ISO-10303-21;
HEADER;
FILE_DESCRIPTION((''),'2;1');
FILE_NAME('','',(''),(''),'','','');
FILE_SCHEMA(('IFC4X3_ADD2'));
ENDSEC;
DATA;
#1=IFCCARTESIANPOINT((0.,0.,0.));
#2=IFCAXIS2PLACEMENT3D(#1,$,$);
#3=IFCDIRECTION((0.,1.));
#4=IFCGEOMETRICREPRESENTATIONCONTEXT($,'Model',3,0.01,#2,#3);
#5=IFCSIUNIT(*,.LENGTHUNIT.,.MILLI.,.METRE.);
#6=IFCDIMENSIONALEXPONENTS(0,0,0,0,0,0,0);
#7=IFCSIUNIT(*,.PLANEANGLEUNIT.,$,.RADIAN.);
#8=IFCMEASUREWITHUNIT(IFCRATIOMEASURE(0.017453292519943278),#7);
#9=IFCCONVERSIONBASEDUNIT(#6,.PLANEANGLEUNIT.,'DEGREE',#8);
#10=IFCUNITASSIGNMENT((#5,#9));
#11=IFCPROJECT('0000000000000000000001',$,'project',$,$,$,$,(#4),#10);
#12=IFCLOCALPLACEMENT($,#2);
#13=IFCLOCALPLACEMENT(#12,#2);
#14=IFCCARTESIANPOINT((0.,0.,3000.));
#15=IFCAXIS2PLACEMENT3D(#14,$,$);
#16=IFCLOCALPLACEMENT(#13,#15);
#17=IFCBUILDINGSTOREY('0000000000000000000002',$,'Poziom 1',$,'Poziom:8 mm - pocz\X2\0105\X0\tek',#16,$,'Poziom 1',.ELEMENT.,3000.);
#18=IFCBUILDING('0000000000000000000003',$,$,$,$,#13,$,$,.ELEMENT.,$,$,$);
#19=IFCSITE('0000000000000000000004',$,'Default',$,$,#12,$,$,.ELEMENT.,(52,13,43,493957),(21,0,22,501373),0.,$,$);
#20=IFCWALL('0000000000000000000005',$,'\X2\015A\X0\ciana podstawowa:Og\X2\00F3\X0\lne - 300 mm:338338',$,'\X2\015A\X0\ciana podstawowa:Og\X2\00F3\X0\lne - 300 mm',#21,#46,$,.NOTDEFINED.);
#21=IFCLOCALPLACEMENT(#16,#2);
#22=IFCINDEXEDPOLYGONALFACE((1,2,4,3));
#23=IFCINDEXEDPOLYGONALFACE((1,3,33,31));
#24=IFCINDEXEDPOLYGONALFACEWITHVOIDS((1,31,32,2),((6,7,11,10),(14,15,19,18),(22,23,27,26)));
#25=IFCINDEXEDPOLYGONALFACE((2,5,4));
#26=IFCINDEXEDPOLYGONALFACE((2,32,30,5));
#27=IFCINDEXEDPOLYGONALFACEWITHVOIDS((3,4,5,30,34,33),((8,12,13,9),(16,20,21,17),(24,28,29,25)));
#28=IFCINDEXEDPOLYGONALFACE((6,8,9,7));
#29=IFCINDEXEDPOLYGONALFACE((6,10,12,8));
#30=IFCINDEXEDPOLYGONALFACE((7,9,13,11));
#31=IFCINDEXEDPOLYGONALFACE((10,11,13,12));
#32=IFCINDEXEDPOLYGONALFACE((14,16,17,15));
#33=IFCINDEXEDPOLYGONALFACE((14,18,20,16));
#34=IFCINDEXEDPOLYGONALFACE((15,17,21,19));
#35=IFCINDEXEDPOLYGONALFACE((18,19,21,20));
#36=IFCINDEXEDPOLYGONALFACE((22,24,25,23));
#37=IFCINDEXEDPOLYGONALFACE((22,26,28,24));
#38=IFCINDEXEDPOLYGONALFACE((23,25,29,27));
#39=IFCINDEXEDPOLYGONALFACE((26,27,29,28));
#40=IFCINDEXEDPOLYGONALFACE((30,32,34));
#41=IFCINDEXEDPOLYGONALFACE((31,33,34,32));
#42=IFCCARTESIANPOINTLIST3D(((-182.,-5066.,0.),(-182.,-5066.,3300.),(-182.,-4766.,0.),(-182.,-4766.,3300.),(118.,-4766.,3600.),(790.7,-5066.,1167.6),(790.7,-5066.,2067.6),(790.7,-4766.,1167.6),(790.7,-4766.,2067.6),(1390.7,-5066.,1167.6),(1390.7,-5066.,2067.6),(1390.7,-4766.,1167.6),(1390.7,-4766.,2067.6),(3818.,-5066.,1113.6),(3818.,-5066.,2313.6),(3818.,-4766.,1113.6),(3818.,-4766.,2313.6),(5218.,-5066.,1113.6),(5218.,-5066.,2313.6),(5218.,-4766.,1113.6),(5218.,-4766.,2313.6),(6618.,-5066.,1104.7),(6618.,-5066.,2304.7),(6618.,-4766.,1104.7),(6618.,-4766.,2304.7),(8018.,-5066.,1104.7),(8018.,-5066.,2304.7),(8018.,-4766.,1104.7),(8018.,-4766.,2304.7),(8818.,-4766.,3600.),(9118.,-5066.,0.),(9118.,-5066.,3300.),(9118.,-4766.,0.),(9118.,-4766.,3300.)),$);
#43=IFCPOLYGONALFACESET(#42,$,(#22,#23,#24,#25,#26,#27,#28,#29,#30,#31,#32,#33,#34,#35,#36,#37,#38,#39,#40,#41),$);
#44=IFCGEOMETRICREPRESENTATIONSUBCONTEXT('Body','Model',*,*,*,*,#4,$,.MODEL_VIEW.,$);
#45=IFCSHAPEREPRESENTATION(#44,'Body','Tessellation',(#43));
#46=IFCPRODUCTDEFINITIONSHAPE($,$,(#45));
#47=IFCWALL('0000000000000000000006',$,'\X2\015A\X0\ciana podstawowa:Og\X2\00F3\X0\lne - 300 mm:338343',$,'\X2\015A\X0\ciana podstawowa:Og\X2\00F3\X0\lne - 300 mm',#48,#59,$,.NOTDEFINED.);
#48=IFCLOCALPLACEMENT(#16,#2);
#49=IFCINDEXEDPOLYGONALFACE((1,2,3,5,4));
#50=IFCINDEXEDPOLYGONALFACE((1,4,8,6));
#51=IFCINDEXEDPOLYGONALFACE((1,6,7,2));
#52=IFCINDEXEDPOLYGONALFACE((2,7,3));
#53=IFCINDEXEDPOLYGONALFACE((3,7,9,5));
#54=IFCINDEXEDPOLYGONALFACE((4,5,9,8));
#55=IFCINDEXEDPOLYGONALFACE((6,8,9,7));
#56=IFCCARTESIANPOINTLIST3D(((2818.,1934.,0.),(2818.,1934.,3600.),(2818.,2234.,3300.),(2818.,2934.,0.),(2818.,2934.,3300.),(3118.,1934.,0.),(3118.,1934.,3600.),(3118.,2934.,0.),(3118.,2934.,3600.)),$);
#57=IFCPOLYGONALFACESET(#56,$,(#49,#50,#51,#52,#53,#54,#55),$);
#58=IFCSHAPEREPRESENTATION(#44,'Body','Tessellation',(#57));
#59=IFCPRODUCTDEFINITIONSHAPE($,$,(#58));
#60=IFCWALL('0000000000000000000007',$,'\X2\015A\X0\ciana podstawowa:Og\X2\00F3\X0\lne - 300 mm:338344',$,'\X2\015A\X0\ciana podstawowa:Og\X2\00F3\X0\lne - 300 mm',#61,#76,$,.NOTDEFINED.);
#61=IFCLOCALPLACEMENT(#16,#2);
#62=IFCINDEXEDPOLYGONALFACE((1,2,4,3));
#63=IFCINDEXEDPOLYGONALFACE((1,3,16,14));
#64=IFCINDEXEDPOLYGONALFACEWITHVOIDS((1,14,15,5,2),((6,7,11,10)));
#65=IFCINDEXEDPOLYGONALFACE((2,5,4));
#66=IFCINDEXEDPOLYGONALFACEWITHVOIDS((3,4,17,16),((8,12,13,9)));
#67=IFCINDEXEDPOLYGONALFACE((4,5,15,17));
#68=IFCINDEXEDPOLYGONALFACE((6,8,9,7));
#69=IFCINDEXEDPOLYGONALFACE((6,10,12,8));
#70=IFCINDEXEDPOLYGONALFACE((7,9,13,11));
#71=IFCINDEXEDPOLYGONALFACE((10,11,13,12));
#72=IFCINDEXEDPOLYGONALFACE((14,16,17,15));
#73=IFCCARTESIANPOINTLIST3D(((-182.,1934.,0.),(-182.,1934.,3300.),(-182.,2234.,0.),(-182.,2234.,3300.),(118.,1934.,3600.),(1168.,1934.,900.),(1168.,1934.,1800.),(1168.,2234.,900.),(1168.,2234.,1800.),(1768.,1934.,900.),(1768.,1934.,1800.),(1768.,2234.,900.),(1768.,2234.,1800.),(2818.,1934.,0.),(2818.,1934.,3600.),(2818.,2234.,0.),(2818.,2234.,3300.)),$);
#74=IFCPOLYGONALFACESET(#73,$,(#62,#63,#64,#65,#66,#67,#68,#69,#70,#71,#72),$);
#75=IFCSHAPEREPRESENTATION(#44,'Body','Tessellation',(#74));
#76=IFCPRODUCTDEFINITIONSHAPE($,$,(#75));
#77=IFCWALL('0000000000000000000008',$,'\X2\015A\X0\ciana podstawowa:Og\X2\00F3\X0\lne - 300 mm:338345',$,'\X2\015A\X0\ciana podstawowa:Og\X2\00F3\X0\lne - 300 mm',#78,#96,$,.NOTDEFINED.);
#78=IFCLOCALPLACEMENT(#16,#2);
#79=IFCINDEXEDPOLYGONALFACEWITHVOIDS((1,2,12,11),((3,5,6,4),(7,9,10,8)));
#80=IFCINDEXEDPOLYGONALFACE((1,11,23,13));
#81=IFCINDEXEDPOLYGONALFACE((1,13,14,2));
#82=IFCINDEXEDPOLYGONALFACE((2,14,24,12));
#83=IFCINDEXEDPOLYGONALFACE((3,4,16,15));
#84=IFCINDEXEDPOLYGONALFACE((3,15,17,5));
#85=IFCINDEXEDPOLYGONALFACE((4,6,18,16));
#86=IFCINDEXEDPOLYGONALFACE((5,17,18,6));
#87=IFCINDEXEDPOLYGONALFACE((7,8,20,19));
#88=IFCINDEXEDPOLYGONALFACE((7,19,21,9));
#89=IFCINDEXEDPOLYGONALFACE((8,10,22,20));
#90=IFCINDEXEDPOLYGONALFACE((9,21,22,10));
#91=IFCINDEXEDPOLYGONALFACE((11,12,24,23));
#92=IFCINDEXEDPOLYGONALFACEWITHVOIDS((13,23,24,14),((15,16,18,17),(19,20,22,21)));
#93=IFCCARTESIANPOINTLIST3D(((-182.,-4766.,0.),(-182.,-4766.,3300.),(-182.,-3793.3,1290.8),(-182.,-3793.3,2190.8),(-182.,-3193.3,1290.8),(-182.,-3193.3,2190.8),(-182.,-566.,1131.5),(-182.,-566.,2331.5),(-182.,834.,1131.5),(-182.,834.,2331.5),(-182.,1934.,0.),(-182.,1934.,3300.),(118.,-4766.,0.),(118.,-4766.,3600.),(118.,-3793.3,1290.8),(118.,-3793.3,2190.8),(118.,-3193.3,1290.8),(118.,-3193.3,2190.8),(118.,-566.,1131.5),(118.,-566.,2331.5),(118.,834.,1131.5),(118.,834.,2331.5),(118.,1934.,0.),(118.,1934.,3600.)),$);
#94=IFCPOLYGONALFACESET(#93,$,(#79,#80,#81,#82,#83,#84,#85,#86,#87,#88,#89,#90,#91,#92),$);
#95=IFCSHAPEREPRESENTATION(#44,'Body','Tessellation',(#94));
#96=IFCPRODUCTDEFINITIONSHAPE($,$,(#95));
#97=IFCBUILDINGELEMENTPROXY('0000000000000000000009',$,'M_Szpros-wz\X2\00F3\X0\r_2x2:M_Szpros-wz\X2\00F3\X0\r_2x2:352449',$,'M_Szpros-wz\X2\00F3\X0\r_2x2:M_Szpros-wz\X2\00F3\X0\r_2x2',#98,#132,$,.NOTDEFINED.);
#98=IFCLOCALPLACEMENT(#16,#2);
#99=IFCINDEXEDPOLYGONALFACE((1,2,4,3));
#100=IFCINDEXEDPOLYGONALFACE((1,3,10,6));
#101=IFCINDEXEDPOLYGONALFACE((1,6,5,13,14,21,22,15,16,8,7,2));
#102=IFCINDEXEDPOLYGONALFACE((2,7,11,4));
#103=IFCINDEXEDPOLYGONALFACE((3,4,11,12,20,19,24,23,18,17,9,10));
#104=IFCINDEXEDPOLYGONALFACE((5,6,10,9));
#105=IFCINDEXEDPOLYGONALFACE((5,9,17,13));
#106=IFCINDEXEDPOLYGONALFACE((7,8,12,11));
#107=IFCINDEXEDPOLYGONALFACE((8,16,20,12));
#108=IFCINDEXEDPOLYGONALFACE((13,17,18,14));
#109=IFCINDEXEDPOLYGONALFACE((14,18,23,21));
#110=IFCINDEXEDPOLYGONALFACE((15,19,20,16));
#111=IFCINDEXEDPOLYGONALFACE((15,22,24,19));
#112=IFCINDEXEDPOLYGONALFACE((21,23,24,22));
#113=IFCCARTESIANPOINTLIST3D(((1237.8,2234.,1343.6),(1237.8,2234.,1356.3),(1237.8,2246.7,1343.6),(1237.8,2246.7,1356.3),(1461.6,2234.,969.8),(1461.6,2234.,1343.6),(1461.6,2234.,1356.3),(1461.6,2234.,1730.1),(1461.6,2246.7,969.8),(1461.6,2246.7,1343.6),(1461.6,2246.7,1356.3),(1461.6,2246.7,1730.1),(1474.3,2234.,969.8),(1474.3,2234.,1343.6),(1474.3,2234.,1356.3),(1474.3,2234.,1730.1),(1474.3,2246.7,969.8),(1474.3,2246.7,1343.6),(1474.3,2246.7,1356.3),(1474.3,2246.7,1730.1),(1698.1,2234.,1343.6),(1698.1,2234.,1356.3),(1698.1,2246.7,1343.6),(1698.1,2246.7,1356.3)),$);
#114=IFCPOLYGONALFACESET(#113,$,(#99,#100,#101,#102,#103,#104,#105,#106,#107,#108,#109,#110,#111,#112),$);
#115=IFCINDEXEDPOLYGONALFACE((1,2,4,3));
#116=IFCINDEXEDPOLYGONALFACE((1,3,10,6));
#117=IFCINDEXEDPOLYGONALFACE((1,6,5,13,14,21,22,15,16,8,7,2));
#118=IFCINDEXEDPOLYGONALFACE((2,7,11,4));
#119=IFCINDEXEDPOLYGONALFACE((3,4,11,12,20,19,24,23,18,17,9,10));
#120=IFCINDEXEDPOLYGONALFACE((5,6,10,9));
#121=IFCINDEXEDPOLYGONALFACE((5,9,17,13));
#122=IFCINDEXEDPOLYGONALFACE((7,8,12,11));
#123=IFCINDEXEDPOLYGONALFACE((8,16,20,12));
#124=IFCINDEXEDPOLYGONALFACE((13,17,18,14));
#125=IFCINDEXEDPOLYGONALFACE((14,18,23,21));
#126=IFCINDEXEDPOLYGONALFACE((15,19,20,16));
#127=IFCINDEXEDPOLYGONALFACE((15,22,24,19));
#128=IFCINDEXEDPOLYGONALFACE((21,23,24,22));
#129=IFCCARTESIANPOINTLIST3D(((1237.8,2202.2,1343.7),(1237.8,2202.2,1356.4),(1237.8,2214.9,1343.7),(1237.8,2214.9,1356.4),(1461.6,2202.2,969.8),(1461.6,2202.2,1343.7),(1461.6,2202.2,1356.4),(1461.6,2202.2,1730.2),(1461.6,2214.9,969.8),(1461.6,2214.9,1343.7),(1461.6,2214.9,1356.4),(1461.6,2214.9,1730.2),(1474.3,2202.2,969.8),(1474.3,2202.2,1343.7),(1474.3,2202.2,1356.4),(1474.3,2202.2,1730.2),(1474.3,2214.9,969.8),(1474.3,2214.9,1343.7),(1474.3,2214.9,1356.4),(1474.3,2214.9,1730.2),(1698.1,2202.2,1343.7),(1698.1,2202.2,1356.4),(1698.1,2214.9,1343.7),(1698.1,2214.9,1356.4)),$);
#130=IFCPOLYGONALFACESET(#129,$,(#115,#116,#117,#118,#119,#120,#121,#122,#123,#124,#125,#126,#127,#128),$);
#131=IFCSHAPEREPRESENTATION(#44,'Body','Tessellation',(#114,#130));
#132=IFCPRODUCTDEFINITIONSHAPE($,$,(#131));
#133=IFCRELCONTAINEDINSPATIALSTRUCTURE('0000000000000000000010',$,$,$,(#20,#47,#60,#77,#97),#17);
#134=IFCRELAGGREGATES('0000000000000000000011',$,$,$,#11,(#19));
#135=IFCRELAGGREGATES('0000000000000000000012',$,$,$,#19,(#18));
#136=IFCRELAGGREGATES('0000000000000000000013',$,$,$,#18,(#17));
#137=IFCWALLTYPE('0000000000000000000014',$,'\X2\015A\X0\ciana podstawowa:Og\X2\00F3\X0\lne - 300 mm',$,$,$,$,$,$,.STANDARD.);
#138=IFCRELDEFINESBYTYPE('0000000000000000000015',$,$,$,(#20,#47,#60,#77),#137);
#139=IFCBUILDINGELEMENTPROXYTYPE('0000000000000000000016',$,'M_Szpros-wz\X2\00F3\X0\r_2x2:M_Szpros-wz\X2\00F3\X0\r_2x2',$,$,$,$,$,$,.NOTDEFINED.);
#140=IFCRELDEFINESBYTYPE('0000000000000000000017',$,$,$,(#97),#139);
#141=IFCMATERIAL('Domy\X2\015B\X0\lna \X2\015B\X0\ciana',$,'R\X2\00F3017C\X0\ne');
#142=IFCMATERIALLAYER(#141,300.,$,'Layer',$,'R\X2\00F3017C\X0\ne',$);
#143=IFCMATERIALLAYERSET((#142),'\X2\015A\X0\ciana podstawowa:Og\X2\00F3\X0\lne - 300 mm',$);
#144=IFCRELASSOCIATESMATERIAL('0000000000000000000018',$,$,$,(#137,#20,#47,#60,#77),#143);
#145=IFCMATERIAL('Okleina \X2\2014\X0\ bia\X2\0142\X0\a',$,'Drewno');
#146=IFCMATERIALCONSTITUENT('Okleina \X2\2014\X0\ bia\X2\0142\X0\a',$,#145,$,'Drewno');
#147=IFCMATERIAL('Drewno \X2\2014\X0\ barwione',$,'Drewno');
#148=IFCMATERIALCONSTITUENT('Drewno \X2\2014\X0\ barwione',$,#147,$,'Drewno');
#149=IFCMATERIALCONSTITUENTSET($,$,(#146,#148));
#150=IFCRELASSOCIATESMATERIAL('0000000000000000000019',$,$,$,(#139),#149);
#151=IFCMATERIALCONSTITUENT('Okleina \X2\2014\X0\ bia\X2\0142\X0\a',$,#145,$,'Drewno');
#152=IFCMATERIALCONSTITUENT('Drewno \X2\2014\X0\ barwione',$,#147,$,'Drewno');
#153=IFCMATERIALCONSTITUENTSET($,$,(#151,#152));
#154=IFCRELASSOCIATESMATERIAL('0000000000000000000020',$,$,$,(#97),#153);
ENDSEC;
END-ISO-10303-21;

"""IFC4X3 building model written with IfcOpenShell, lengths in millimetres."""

from ifc_helpers import new_model, entity, si_unit, converted_unit, direction, frame, frame_2d, origin, place, context, subcontext, project, spatial, polyline, rectangle, outline, extrude, clip, bounded_halfspace, source, transform, mapped, material, layer, layer_set, constituent, constituent_set, type_object, type_shapes, element, save


model = new_model("IFC4X3")

# Units and contexts
model_context = context("Model", 3, precision=0.01, world=origin(), true_north=direction((0.0, 1.0)))
body_context = subcontext(model_context, "Body", "Model", "MODEL_VIEW")
ifc_project = project(units=[si_unit("LENGTHUNIT", "METRE", prefix="MILLI"), converted_unit("PLANEANGLEUNIT", "DEGREE", entity("IfcRatioMeasure", 0.017453292519943278), si_unit("PLANEANGLEUNIT", "RADIAN"), dimensions=[0, 0, 0, 0, 0, 0, 0])], contexts=[model_context])

# Site, building, storey
site_placement = place(None, origin())
site = spatial("IfcSite", under=ifc_project, at=site_placement, Name="Default", CompositionType="ELEMENT", RefLatitude=(52, 13, 43, 493957), RefLongitude=(21, 0, 22, 501373), RefElevation=0.0)
building_placement = place(site_placement, origin())
building = spatial("IfcBuilding", under=site, at=building_placement, CompositionType="ELEMENT")
storey_placement = place(building_placement, frame((0.0, 0.0, 3000.0)))
storey = spatial("IfcBuildingStorey", under=building, at=storey_placement, Name="Poziom 1", ObjectType="Poziom:8 mm - początek", LongName="Poziom 1", CompositionType="ELEMENT", Elevation=3000.0)

# Wall, openings
ifc_material_1 = material(Name="Domyślna ściana", Category="Różne")
ifc_layer_1 = layer(ifc_material_1, 300.0, Name="Layer", Category="Różne")
ifc_layer_set_1 = layer_set([ifc_layer_1], Name="Ściana podstawowa:Ogólne - 300 mm")
wall_type = type_object("IfcWallType", Name="Ściana podstawowa:Ogólne - 300 mm", PredefinedType="STANDARD", material=ifc_layer_set_1)
wall_1_placement = place(storey_placement, frame((-182.0, -4916.0, 0.0)))
wall_1 = element("IfcWall", 1, at=wall_1_placement, inside=storey, type_object=wall_type, material=ifc_layer_set_1, Name="Ściana podstawowa:Ogólne - 300 mm:338338", ObjectType="Ściana podstawowa:Ogólne - 300 mm", PredefinedType="NOTDEFINED", context=body_context, shape_type="Clipping", body=[
    clip(clip(clip(extrude(rectangle(XDim=9300.0, YDim=300.0, at=frame_2d((4650.0, 0.0), x_axis=(-1.0, 0.0))), origin(), (0.0, 0.0, 1.0), 3600.0), bounded_halfspace(frame((9300.0, -150.0, 3300.0), z_axis=(0.707107, 0.0, 0.707107), x_axis=(0.0, 1.0, 0.0)), False, frame((9300.0, -150.0, 3300.0)), polyline([(0.0, 0.0), (0.0, 300.0), (-300.0, 300.0), (0.0, 0.0)]))), bounded_halfspace(frame((300.0, 150.0, 3600.0), z_axis=(-0.707107, 0.0, 0.707107), x_axis=(0.0, -1.0, 0.0)), False, frame((300.0, 150.0, 3600.0)), polyline([(0.0, 0.0), (-300.0, 0.0), (-300.0, -300.0), (0.0, 0.0)]))), bounded_halfspace(frame((0.0, -150.0, 3300.0), z_axis=(0.0, -0.707107, 0.707107), x_axis=(1.0, 0.0, 0.0)), False, frame((0.0, -150.0, 3300.0)), polyline([(0.0, 0.0), (9300.0, 0.0), (9000.0, 300.0), (300.0, 300.0), (0.0, 0.0)]))),
])
opening_1_placement = place(wall_1_placement, frame((8200.0, 150.0, 1104.7)))
element("IfcOpeningElement", 2, at=opening_1_placement, cuts=wall_1, PredefinedType="OPENING", context=body_context, shape_type="SweptSolid", body=[
    extrude(rectangle(XDim=1200.0, YDim=1400.0, at=frame_2d((600.0, 700.0), x_axis=(-1.0, 0.0))), frame((0.0, 0.0, 0.0), z_axis=(0.0, -1.0, 0.0), x_axis=(0.0, 0.0, 1.0)), (0.0, 0.0, 1.0), 300.0),
])
opening_2_placement = place(wall_1_placement, frame((1572.7, 150.0, 1167.6)))
element("IfcOpeningElement", 3, at=opening_2_placement, cuts=wall_1, PredefinedType="OPENING", context=body_context, shape_type="SweptSolid", body=[
    extrude(rectangle(XDim=900.0, YDim=600.0, at=frame_2d((450.0, 300.0), x_axis=(-1.0, 0.0))), frame((0.0, 0.0, 0.0), z_axis=(0.0, -1.0, 0.0), x_axis=(0.0, 0.0, 1.0)), (0.0, 0.0, 1.0), 300.0),
])
opening_3_placement = place(wall_1_placement, frame((5400.0, 150.0, 1113.6)))
element("IfcOpeningElement", 4, at=opening_3_placement, cuts=wall_1, PredefinedType="OPENING", context=body_context, shape_type="SweptSolid", body=[
    extrude(rectangle(XDim=1200.0, YDim=1400.0, at=frame_2d((600.0, 700.0), x_axis=(-1.0, 0.0))), frame((0.0, 0.0, 0.0), z_axis=(0.0, -1.0, 0.0), x_axis=(0.0, 0.0, 1.0)), (0.0, 0.0, 1.0), 300.0),
])

# Wall
wall_2_placement = place(storey_placement, frame((2968.0, 2934.0, 0.0), z_axis=(0.0, 0.0, 1.0), x_axis=(0.0, -1.0, 0.0)))
element("IfcWall", 5, at=wall_2_placement, inside=storey, type_object=wall_type, material=ifc_layer_set_1, Name="Ściana podstawowa:Ogólne - 300 mm:338343", ObjectType="Ściana podstawowa:Ogólne - 300 mm", PredefinedType="NOTDEFINED", context=body_context, shape_type="Clipping", body=[
    clip(clip(extrude(rectangle(XDim=1000.0, YDim=300.0, at=frame_2d((500.0, 0.0), x_axis=(-1.0, 0.0))), origin(), (0.0, 0.0, 1.0), 3600.0), bounded_halfspace(frame((700.0, -150.0, 3300.0), z_axis=(-0.707107, 0.0, 0.707107), x_axis=(0.0, -1.0, 0.0)), False, frame((700.0, -150.0, 3300.0)), polyline([(0.0, 0.0), (300.0, 0.0), (300.0, 300.0), (0.0, 0.0)]))), bounded_halfspace(frame((0.0, -150.0, 3300.0), z_axis=(0.0, -0.707107, 0.707107), x_axis=(1.0, 0.0, 0.0)), False, frame((0.0, -150.0, 3300.0)), polyline([(0.0, 0.0), (700.0, 0.0), (1000.0, 300.0), (0.0, 300.0), (0.0, 0.0)]))),
])

# Wall, opening
wall_3_placement = place(storey_placement, frame((2818.0, 2084.0, 0.0), z_axis=(0.0, 0.0, 1.0), x_axis=(-1.0, 0.0, 0.0)))
wall_3 = element("IfcWall", 6, at=wall_3_placement, inside=storey, type_object=wall_type, material=ifc_layer_set_1, Name="Ściana podstawowa:Ogólne - 300 mm:338344", ObjectType="Ściana podstawowa:Ogólne - 300 mm", PredefinedType="NOTDEFINED", context=body_context, shape_type="Clipping", body=[
    clip(clip(extrude(rectangle(XDim=3000.0, YDim=300.0, at=frame_2d((1500.0, 0.0), x_axis=(-1.0, 0.0))), origin(), (0.0, 0.0, 1.0), 3600.0), bounded_halfspace(frame((3000.0, -150.0, 3300.0), z_axis=(0.707107, 0.0, 0.707107), x_axis=(0.0, 1.0, 0.0)), False, frame((3000.0, -150.0, 3300.0)), polyline([(0.0, 0.0), (0.0, 300.0), (-300.0, 300.0), (0.0, 0.0)]))), bounded_halfspace(frame((0.0, -150.0, 3300.0), z_axis=(0.0, -0.707107, 0.707107), x_axis=(1.0, 0.0, 0.0)), False, frame((0.0, -150.0, 3300.0)), polyline([(0.0, 0.0), (3000.0, 0.0), (2700.0, 300.0), (0.0, 300.0), (0.0, 0.0)]))),
])
opening_4_placement = place(wall_3_placement, frame((1650.0, 150.0, 900.0)))
element("IfcOpeningElement", 7, at=opening_4_placement, cuts=wall_3, PredefinedType="OPENING", context=body_context, shape_type="SweptSolid", body=[
    extrude(rectangle(XDim=900.0, YDim=600.0, at=frame_2d((450.0, 300.0), x_axis=(-1.0, 0.0))), frame((0.0, 0.0, 0.0), z_axis=(0.0, -1.0, 0.0), x_axis=(0.0, 0.0, 1.0)), (0.0, 0.0, 1.0), 300.0),
])

# Wall, openings
wall_4_placement = place(storey_placement, frame((-32.0, 1934.0, 0.0), z_axis=(0.0, 0.0, 1.0), x_axis=(0.0, -1.0, 0.0)))
wall_4 = element("IfcWall", 8, at=wall_4_placement, inside=storey, type_object=wall_type, material=ifc_layer_set_1, Name="Ściana podstawowa:Ogólne - 300 mm:338345", ObjectType="Ściana podstawowa:Ogólne - 300 mm", PredefinedType="NOTDEFINED", context=body_context, shape_type="Clipping", body=[
    clip(extrude(rectangle(XDim=6700.0, YDim=300.0, at=frame_2d((3350.0, 0.0), x_axis=(-1.0, 0.0))), origin(), (0.0, 0.0, 1.0), 3600.0), bounded_halfspace(frame((0.0, -150.0, 3300.0), z_axis=(0.0, -0.707107, 0.707107), x_axis=(1.0, 0.0, 0.0)), False, frame((0.0, -150.0, 3300.0)), polyline([(0.0, 0.0), (6700.0, 0.0), (6700.0, 300.0), (0.0, 300.0), (0.0, 0.0)]))),
])
opening_5_placement = place(wall_4_placement, frame((2500.0, 150.0, 1131.5)))
element("IfcOpeningElement", 9, at=opening_5_placement, cuts=wall_4, PredefinedType="OPENING", context=body_context, shape_type="SweptSolid", body=[
    extrude(rectangle(XDim=1200.0, YDim=1400.0, at=frame_2d((600.0, 700.0), x_axis=(-1.0, 0.0))), frame((0.0, 0.0, 0.0), z_axis=(0.0, -1.0, 0.0), x_axis=(0.0, 0.0, 1.0)), (0.0, 0.0, 1.0), 300.0),
])
opening_6_placement = place(wall_4_placement, frame((5727.3, 150.0, 1290.8)))
element("IfcOpeningElement", 10, at=opening_6_placement, cuts=wall_4, PredefinedType="OPENING", context=body_context, shape_type="SweptSolid", body=[
    extrude(rectangle(XDim=900.0, YDim=600.0, at=frame_2d((450.0, 300.0), x_axis=(-1.0, 0.0))), frame((0.0, 0.0, 0.0), z_axis=(0.0, -1.0, 0.0), x_axis=(0.0, 0.0, 1.0)), (0.0, 0.0, 1.0), 300.0),
])

# Building element proxy
ifc_material_2 = material(Name="Okleina — biała", Category="Drewno")
ifc_constituent_1 = constituent(ifc_material_2, Name="Okleina — biała", Category="Drewno")
ifc_material_3 = material(Name="Drewno — barwione", Category="Drewno")
ifc_constituent_2 = constituent(ifc_material_3, Name="Drewno — barwione", Category="Drewno")
ifc_constituent_set_1 = constituent_set(constituents=[ifc_constituent_1, ifc_constituent_2])
ifc_constituent_3 = constituent(ifc_material_2, Name="Okleina — biała", Category="Drewno")
ifc_constituent_4 = constituent(ifc_material_3, Name="Drewno — barwione", Category="Drewno")
ifc_constituent_set_2 = constituent_set(constituents=[ifc_constituent_3, ifc_constituent_4])
building_element_proxy_type_1 = type_object("IfcBuildingElementProxyType", Name="M_Szpros-wzór_2x2:M_Szpros-wzór_2x2", PredefinedType="NOTDEFINED", material=ifc_constituent_set_2)
shared_shape_1 = source(origin(), body_context, "Body", "SweptSolid", [
    extrude(outline(polyline([(6.4, -6.4), (380.1, -6.4), (380.1, 6.3), (6.4, 6.3), (6.4, 230.2), (-6.3, 230.2), (-6.3, 6.3), (-380.2, 6.3), (-380.2, -6.4), (-6.3, -6.4), (-6.3, -230.1), (6.4, -230.1), (6.4, -6.4)])), frame((0.0, 9.5, 380.1), z_axis=(0.0, 1.0, 0.0), x_axis=(0.0, 0.0, 1.0)), (0.0, 0.0, 1.0), 12.7),
    extrude(outline(polyline([(6.4, -6.4), (380.2, -6.4), (380.2, 6.3), (6.4, 6.3), (6.4, 230.2), (-6.3, 230.2), (-6.3, 6.3), (-380.2, 6.3), (-380.2, -6.4), (-6.3, -6.4), (-6.3, -230.1), (6.4, -230.1), (6.4, -6.4)])), frame((0.0, -22.2, 380.2), z_axis=(0.0, 1.0, 0.0), x_axis=(0.0, 0.0, 1.0)), (0.0, 0.0, 1.0), 12.7),
])
type_shapes(building_element_proxy_type_1, [shared_shape_1])
proxy_1_placement = place(storey_placement, frame((1468.0, 2224.5, 969.8)))
element("IfcBuildingElementProxy", 11, at=proxy_1_placement, inside=storey, type_object=building_element_proxy_type_1, material=ifc_constituent_set_1, Name="M_Szpros-wzór_2x2:M_Szpros-wzór_2x2:352449", ObjectType="M_Szpros-wzór_2x2:M_Szpros-wzór_2x2", PredefinedType="NOTDEFINED", context=body_context, shape_type="MappedRepresentation", body=[
    mapped(shared_shape_1, transform((0.0, 0.0, 0.0), scale=1.0)),
])

save(model, "model.ifc")
